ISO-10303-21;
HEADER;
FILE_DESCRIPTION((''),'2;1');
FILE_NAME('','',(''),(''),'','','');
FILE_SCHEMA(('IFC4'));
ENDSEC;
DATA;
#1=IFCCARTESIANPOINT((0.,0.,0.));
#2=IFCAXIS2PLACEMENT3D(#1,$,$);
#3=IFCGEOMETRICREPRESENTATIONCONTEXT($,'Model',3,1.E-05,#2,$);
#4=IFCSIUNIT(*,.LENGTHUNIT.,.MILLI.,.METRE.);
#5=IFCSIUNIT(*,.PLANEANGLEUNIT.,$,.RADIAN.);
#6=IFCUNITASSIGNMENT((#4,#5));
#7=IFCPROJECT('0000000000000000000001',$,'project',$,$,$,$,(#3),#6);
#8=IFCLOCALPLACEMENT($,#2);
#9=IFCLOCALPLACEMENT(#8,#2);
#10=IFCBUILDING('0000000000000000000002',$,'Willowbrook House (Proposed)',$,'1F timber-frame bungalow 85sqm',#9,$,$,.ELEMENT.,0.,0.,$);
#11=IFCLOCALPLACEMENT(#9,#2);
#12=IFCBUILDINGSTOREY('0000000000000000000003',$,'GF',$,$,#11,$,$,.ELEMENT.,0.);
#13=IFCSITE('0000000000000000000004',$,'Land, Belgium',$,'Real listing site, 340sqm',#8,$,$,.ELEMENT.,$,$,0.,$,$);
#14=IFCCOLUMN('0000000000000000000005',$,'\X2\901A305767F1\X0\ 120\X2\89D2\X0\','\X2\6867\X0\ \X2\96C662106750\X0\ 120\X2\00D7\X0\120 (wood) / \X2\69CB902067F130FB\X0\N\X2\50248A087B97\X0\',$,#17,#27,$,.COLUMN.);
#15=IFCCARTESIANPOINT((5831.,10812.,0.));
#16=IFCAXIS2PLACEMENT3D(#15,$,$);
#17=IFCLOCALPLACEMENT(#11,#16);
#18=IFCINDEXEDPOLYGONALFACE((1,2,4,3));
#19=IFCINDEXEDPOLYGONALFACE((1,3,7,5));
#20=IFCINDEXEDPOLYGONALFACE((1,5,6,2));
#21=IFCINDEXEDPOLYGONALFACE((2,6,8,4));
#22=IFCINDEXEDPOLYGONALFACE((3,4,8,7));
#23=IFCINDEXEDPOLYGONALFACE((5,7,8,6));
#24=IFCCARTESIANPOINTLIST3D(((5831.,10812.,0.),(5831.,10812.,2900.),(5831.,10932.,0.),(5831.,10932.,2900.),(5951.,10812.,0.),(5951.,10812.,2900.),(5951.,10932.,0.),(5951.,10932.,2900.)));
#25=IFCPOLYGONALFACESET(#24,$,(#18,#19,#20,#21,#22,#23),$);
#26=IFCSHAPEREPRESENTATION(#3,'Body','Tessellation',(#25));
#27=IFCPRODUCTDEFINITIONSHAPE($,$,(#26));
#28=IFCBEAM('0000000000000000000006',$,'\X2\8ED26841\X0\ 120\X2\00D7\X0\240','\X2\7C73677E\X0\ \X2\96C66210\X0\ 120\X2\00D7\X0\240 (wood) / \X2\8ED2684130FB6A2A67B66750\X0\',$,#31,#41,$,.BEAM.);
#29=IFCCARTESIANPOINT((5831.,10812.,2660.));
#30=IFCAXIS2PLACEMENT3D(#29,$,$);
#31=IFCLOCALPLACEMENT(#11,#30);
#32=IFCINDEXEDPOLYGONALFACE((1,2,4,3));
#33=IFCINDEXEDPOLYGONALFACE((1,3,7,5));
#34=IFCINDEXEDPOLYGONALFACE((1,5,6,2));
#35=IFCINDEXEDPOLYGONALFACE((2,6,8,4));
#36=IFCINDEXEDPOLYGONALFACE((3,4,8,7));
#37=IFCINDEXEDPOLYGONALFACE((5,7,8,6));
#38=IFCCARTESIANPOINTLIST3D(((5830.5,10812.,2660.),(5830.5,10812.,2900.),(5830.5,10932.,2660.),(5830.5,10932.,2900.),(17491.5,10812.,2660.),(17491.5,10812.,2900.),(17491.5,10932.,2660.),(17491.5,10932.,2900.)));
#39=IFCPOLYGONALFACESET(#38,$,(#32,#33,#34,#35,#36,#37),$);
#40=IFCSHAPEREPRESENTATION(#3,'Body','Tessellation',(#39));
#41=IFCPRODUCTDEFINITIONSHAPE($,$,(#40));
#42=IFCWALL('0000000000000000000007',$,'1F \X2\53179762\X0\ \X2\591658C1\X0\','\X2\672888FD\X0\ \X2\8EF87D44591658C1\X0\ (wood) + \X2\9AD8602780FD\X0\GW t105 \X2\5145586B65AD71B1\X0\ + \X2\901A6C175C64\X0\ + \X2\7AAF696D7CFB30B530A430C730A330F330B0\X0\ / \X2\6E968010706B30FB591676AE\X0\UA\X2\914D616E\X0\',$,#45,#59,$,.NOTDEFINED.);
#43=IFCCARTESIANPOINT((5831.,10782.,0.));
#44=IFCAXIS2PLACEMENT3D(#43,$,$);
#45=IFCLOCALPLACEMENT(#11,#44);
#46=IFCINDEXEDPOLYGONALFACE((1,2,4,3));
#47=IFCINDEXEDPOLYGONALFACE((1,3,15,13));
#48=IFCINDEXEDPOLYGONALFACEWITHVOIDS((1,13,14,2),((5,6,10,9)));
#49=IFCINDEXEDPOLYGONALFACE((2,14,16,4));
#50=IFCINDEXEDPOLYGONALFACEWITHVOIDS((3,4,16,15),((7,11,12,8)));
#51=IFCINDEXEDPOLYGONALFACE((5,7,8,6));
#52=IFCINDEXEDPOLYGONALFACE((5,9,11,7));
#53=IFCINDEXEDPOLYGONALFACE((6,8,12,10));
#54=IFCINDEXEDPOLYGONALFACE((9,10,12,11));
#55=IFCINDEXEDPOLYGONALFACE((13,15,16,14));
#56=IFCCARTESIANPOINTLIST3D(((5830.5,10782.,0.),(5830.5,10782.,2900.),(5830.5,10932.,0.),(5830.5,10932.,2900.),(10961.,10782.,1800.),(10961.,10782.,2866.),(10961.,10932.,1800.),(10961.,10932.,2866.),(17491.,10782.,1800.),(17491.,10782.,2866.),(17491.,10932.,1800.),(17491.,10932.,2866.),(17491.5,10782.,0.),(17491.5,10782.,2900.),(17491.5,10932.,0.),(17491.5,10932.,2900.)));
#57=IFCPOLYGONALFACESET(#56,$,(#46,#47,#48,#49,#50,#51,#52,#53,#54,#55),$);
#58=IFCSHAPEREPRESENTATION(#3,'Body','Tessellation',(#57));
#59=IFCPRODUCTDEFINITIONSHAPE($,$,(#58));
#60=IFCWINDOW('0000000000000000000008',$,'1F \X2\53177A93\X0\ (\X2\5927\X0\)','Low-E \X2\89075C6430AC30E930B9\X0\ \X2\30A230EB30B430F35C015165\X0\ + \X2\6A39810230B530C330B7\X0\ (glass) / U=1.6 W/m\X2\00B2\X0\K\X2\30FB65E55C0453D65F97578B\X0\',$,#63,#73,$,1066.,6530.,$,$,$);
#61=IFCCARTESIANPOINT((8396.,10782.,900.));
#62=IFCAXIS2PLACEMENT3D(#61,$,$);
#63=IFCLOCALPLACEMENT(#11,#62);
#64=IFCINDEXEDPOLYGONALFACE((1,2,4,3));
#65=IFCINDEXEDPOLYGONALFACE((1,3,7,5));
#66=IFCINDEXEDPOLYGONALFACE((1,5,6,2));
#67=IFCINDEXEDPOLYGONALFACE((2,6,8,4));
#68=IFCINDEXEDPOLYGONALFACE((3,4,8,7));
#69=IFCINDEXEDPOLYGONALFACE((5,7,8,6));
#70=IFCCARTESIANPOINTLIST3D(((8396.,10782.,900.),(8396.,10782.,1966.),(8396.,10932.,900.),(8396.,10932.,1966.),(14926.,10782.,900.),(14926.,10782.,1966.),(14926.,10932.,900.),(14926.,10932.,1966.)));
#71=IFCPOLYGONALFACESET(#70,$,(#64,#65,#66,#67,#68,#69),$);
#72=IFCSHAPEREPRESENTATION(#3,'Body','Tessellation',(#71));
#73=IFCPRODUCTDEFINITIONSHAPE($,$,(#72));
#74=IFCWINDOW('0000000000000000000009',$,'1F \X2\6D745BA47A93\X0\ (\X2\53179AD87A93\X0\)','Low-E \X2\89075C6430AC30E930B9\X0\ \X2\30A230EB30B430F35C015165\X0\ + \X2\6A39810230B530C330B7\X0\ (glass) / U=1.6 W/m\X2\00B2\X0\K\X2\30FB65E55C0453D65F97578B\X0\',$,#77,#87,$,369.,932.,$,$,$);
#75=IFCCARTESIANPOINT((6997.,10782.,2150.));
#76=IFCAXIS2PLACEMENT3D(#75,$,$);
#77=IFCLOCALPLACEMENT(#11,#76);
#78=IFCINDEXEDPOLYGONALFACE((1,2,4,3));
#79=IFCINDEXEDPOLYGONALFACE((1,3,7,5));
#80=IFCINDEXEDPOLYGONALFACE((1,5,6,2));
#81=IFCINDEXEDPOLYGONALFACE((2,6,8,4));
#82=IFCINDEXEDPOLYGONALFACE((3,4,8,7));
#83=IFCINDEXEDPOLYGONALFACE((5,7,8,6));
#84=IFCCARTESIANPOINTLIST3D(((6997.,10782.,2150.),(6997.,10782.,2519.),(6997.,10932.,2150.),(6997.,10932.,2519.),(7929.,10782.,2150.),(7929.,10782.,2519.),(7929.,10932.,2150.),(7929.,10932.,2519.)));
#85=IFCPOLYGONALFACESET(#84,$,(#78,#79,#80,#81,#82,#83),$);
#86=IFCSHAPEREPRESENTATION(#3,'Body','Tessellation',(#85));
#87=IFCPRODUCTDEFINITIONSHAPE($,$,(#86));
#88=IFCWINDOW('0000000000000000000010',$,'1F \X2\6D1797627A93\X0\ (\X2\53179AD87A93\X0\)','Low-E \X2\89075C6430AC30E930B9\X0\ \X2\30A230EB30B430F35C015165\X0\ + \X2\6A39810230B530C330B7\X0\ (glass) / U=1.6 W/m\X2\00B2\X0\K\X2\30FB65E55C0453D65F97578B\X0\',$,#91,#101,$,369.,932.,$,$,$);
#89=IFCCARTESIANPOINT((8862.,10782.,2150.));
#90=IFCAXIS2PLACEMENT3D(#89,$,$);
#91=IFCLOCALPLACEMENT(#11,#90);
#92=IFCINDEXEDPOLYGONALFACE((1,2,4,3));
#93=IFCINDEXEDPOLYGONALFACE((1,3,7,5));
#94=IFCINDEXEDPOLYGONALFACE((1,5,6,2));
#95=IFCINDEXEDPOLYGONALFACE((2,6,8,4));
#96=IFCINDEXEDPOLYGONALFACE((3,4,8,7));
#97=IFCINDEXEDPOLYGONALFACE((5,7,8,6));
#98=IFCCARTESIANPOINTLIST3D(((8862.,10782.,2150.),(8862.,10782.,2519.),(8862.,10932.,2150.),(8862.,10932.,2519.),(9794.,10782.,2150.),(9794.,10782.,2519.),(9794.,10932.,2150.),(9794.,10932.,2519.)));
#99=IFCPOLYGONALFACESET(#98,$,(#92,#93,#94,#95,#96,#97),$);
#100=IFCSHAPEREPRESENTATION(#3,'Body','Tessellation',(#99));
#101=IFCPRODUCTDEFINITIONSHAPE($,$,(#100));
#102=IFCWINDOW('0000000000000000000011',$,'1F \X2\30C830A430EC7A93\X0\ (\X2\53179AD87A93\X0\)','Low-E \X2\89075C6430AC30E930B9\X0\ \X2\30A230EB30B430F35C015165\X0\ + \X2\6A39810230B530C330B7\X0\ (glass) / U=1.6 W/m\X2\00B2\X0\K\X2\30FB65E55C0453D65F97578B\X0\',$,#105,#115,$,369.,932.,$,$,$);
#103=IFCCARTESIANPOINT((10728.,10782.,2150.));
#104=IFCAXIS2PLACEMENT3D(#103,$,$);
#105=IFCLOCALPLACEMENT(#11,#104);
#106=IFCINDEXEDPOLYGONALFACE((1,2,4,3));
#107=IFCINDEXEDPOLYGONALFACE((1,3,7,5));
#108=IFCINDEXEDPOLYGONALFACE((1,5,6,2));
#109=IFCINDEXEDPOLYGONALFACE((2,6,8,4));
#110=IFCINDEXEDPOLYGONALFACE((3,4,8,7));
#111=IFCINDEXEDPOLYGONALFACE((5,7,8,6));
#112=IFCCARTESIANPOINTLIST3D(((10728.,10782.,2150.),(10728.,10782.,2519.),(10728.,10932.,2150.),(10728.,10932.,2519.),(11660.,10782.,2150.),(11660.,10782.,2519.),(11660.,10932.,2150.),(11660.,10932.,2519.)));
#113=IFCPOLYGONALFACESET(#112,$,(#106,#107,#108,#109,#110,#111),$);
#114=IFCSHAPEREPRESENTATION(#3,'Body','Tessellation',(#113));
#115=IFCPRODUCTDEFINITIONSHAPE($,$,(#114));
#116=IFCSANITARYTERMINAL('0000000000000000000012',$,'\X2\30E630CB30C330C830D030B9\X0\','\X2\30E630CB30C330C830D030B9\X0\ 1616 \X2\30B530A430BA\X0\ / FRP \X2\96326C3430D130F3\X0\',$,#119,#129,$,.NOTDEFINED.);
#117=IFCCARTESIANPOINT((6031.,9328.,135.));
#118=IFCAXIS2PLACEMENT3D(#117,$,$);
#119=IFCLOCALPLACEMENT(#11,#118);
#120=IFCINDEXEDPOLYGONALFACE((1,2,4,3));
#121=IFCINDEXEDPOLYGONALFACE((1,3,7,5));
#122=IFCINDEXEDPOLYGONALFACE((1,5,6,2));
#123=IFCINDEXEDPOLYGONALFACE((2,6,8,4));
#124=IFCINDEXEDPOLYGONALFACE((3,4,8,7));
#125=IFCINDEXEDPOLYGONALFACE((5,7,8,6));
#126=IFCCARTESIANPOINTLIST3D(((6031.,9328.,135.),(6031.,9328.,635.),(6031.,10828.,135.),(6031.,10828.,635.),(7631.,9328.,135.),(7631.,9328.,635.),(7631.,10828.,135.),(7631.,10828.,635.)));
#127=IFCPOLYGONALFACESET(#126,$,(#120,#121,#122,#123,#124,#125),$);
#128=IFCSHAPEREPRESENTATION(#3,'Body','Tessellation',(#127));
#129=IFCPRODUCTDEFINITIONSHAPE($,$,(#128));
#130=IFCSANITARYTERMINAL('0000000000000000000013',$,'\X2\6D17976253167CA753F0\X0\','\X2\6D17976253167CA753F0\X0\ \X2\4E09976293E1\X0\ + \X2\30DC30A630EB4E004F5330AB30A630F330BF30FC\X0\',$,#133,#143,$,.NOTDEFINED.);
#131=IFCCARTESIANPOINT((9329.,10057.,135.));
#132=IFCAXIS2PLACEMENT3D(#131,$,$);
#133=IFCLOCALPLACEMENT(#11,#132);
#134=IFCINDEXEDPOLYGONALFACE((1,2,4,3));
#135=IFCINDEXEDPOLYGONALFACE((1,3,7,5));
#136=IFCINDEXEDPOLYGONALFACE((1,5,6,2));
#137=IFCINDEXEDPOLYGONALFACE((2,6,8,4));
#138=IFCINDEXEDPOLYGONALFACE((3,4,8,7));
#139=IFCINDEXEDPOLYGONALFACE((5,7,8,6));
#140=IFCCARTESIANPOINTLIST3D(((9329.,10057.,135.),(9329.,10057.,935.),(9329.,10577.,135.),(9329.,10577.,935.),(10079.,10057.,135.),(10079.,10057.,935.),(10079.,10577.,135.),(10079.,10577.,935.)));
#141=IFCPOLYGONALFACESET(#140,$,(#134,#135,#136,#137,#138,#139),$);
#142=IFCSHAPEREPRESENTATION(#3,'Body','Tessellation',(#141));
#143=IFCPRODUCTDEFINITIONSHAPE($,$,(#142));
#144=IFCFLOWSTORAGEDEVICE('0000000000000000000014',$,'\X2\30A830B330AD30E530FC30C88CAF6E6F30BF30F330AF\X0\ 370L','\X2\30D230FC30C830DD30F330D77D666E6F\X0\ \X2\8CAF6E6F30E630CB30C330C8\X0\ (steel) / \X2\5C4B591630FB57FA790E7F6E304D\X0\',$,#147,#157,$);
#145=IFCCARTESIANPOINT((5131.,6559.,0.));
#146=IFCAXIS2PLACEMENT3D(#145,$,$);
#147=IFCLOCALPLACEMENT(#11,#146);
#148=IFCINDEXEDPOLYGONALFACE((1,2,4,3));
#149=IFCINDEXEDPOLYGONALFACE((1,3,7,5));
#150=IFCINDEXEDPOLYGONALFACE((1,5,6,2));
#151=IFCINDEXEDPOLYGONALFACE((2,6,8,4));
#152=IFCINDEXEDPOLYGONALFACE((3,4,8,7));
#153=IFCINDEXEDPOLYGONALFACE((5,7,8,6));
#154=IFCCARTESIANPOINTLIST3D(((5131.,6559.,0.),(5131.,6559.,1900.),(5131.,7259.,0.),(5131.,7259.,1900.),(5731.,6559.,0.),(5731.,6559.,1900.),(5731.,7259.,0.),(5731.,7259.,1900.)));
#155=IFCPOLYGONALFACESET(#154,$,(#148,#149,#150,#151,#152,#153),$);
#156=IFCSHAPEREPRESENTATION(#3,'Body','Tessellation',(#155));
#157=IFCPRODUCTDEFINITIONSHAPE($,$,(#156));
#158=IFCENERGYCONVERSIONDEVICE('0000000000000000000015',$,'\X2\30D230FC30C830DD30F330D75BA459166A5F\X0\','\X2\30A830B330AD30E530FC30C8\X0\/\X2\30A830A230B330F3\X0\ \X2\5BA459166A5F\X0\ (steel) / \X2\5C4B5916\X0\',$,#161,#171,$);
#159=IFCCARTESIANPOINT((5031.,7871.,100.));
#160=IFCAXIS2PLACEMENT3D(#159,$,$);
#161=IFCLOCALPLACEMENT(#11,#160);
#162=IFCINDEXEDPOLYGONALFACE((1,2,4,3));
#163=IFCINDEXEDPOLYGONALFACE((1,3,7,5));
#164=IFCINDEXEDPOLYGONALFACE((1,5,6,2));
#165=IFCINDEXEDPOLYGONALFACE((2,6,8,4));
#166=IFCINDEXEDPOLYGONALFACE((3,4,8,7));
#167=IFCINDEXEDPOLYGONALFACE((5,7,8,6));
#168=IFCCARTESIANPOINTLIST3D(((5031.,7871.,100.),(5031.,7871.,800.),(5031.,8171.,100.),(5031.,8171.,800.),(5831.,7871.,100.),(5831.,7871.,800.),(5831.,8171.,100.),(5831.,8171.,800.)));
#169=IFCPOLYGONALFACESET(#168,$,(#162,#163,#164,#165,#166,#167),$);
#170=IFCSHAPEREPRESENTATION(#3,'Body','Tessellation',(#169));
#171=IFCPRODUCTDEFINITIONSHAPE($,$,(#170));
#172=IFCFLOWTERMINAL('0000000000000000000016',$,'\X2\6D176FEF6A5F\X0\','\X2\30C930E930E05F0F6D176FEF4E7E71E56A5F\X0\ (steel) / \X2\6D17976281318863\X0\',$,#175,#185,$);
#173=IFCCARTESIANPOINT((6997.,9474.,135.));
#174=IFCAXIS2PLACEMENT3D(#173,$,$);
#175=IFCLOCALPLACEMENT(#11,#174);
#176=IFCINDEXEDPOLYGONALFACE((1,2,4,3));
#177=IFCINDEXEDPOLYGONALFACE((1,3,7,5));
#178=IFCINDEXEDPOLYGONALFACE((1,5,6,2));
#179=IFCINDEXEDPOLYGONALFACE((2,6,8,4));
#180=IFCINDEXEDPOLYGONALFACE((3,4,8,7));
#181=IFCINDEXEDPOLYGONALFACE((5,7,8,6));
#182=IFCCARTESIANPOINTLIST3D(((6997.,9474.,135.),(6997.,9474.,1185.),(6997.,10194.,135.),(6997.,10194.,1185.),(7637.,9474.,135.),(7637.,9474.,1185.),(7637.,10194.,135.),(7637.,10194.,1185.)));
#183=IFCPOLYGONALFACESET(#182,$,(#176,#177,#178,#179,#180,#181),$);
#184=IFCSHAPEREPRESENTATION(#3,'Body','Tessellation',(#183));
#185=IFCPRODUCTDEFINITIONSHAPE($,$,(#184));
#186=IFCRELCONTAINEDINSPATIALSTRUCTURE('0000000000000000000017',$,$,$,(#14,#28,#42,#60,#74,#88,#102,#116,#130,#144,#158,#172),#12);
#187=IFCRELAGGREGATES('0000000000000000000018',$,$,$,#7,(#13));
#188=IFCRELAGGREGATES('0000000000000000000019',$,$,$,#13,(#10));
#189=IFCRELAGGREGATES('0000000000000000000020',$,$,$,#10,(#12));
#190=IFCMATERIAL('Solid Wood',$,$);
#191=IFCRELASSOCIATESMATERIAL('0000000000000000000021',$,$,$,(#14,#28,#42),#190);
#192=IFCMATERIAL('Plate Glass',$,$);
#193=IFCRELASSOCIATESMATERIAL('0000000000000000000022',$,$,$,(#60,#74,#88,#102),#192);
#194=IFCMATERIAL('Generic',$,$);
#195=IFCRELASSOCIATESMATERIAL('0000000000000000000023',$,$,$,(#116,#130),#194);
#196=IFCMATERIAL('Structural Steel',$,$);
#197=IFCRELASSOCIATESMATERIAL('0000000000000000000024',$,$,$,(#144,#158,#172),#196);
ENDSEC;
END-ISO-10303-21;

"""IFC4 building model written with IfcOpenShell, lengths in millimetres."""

from ifc_helpers import new_model, si_unit, frame, frame_2d, origin, place, context, project, spatial, rectangle, extrude, material, element, fill, save


model = new_model("IFC4")

# Units and contexts
model_context = context("Model", 3, precision=1e-05, world=origin())
ifc_project = project(units=[si_unit("LENGTHUNIT", "METRE", prefix="MILLI"), si_unit("PLANEANGLEUNIT", "RADIAN")], contexts=[model_context])

# Site, building, storey
site_placement = place(None, origin())
site = spatial("IfcSite", under=ifc_project, at=site_placement, Name="Land, Belgium", ObjectType="Real listing site, 340sqm", CompositionType="ELEMENT", RefElevation=0.0)
building_placement = place(site_placement, origin())
building = spatial("IfcBuilding", under=site, at=building_placement, Name="Willowbrook House (Proposed)", ObjectType="1F timber-frame bungalow 85sqm", CompositionType="ELEMENT", ElevationOfRefHeight=0.0, ElevationOfTerrain=0.0)
storey_placement = place(building_placement, origin())
storey = spatial("IfcBuildingStorey", under=building, at=storey_placement, Name="GF", CompositionType="ELEMENT", Elevation=0.0)

# Column
ifc_material_1 = material(Name="Solid Wood")
column_1_placement = place(storey_placement, frame((5831.0, 10812.0, 0.0)))
element("IfcColumn", 1, at=column_1_placement, inside=storey, material=ifc_material_1, Name="通し柱 120角", Description="桧 集成材 120×120 (wood) / 構造柱・N値計算", PredefinedType="COLUMN", context=model_context, shape_type="SweptSolid", body=[
    extrude(rectangle(XDim=120.0, YDim=120.0, at=frame_2d((60.0, 60.0))), frame((5831.0, 10812.0, 0.0)), (0.0, 0.0, 1.0), 2900.0),
])

# Beam
beam_1_placement = place(storey_placement, frame((5831.0, 10812.0, 2660.0)))
element("IfcBeam", 2, at=beam_1_placement, inside=storey, material=ifc_material_1, Name="軒桁 120×240", Description="米松 集成 120×240 (wood) / 軒桁・横架材", PredefinedType="BEAM", context=model_context, shape_type="SweptSolid", body=[
    extrude(rectangle(XDim=11661.0, YDim=120.0, at=frame_2d((5830.0, 60.0))), frame((5831.0, 10812.0, 2660.0)), (0.0, 0.0, 1.0), 240.0),
])

# Wall, openings, windows
wall_1_placement = place(storey_placement, frame((5831.0, 10782.0, 0.0)))
wall_1 = element("IfcWall", 3, at=wall_1_placement, inside=storey, material=ifc_material_1, Name="1F 北面 外壁", Description="木製 軸組外壁 (wood) + 高性能GW t105 充填断熱 + 通気層 + 窯業系サイディング / 準耐火・外皮UA配慮", PredefinedType="NOTDEFINED", context=model_context, shape_type="SweptSolid", body=[
    extrude(rectangle(XDim=11661.0, YDim=150.0, at=frame_2d((5830.0, 75.0))), frame((5831.0, 10782.0, 0.0)), (0.0, 0.0, 1.0), 2900.0),
])
opening_1_placement = place(storey_placement, frame((8396.0, 10782.0, 900.0)))
opening_1 = element("IfcOpeningElement", 4, at=opening_1_placement, cuts=wall_1, PredefinedType="NOTDEFINED", context=model_context, shape_type="SweptSolid", body=[
    extrude(rectangle(XDim=6530.0, YDim=150.0, at=frame_2d((3265.0, 75.0))), frame((8396.0, 10782.0, 900.0)), (0.0, 0.0, 1.0), 1066.0),
])
opening_2_placement = place(storey_placement, frame((6997.0, 10782.0, 2150.0)))
opening_2 = element("IfcOpeningElement", 5, at=opening_2_placement, cuts=wall_1, PredefinedType="NOTDEFINED", context=model_context, shape_type="SweptSolid", body=[
    extrude(rectangle(XDim=932.0, YDim=150.0, at=frame_2d((466.0, 75.0))), frame((6997.0, 10782.0, 2150.0)), (0.0, 0.0, 1.0), 369.0),
])
opening_3_placement = place(storey_placement, frame((8862.0, 10782.0, 2150.0)))
opening_3 = element("IfcOpeningElement", 6, at=opening_3_placement, cuts=wall_1, PredefinedType="NOTDEFINED", context=model_context, shape_type="SweptSolid", body=[
    extrude(rectangle(XDim=932.0, YDim=150.0, at=frame_2d((466.0, 75.0))), frame((8862.0, 10782.0, 2150.0)), (0.0, 0.0, 1.0), 369.0),
])
opening_4_placement = place(storey_placement, frame((10728.0, 10782.0, 2150.0)))
opening_4 = element("IfcOpeningElement", 7, at=opening_4_placement, cuts=wall_1, PredefinedType="NOTDEFINED", context=model_context, shape_type="SweptSolid", body=[
    extrude(rectangle(XDim=932.0, YDim=150.0, at=frame_2d((466.0, 75.0))), frame((10728.0, 10782.0, 2150.0)), (0.0, 0.0, 1.0), 369.0),
])
ifc_material_2 = material(Name="Plate Glass")
window_1_placement = place(storey_placement, frame((8396.0, 10782.0, 900.0)))
window_1 = element("IfcWindow", 8, at=window_1_placement, inside=storey, material=ifc_material_2, Name="1F 北窓 (大)", Description="Low-E 複層ガラス アルゴン封入 + 樹脂サッシ (glass) / U=1.6 W/m²K・日射取得型", OverallHeight=1066.0, OverallWidth=6530.0, context=model_context, shape_type="SweptSolid", body=[
    extrude(rectangle(XDim=6530.0, YDim=150.0, at=frame_2d((3265.0, 75.0))), frame((8396.0, 10782.0, 900.0)), (0.0, 0.0, 1.0), 1066.0),
])
fill(opening_1, window_1)
window_2_placement = place(storey_placement, frame((6997.0, 10782.0, 2150.0)))
window_2 = element("IfcWindow", 9, at=window_2_placement, inside=storey, material=ifc_material_2, Name="1F 浴室窓 (北高窓)", Description="Low-E 複層ガラス アルゴン封入 + 樹脂サッシ (glass) / U=1.6 W/m²K・日射取得型", OverallHeight=369.0, OverallWidth=932.0, context=model_context, shape_type="SweptSolid", body=[
    extrude(rectangle(XDim=932.0, YDim=150.0, at=frame_2d((466.0, 75.0))), frame((6997.0, 10782.0, 2150.0)), (0.0, 0.0, 1.0), 369.0),
])
fill(opening_2, window_2)
window_3_placement = place(storey_placement, frame((8862.0, 10782.0, 2150.0)))
window_3 = element("IfcWindow", 10, at=window_3_placement, inside=storey, material=ifc_material_2, Name="1F 洗面窓 (北高窓)", Description="Low-E 複層ガラス アルゴン封入 + 樹脂サッシ (glass) / U=1.6 W/m²K・日射取得型", OverallHeight=369.0, OverallWidth=932.0, context=model_context, shape_type="SweptSolid", body=[
    extrude(rectangle(XDim=932.0, YDim=150.0, at=frame_2d((466.0, 75.0))), frame((8862.0, 10782.0, 2150.0)), (0.0, 0.0, 1.0), 369.0),
])
fill(opening_3, window_3)
window_4_placement = place(storey_placement, frame((10728.0, 10782.0, 2150.0)))
window_4 = element("IfcWindow", 11, at=window_4_placement, inside=storey, material=ifc_material_2, Name="1F トイレ窓 (北高窓)", Description="Low-E 複層ガラス アルゴン封入 + 樹脂サッシ (glass) / U=1.6 W/m²K・日射取得型", OverallHeight=369.0, OverallWidth=932.0, context=model_context, shape_type="SweptSolid", body=[
    extrude(rectangle(XDim=932.0, YDim=150.0, at=frame_2d((466.0, 75.0))), frame((10728.0, 10782.0, 2150.0)), (0.0, 0.0, 1.0), 369.0),
])
fill(opening_4, window_4)

# Sanitary terminals
ifc_material_3 = material(Name="Generic")
sanitary_terminal_1_placement = place(storey_placement, frame((6031.0, 9328.0, 135.0)))
element("IfcSanitaryTerminal", 12, at=sanitary_terminal_1_placement, inside=storey, material=ifc_material_3, Name="ユニットバス", Description="ユニットバス 1616 サイズ / FRP 防水パン", PredefinedType="NOTDEFINED", context=model_context, shape_type="SweptSolid", body=[
    extrude(rectangle(XDim=1600.0, YDim=1500.0, at=frame_2d((800.0, 750.0))), frame((6031.0, 9328.0, 135.0)), (0.0, 0.0, 1.0), 500.0),
])
sanitary_terminal_2_placement = place(storey_placement, frame((9329.0, 10057.0, 135.0)))
element("IfcSanitaryTerminal", 13, at=sanitary_terminal_2_placement, inside=storey, material=ifc_material_3, Name="洗面化粧台", Description="洗面化粧台 三面鏡 + ボウル一体カウンター", PredefinedType="NOTDEFINED", context=model_context, shape_type="SweptSolid", body=[
    extrude(rectangle(XDim=750.0, YDim=520.0, at=frame_2d((375.0, 260.0))), frame((9329.0, 10057.0, 135.0)), (0.0, 0.0, 1.0), 800.0),
])

# Flow storage device
ifc_material_4 = material(Name="Structural Steel")
flow_storage_device_placement = place(storey_placement, frame((5131.0, 6559.0, 0.0)))
element("IfcFlowStorageDevice", 14, at=flow_storage_device_placement, inside=storey, material=ifc_material_4, Name="エコキュート貯湯タンク 370L", Description="ヒートポンプ給湯 貯湯ユニット (steel) / 屋外・基礎置き", context=model_context, shape_type="SweptSolid", body=[
    extrude(rectangle(XDim=600.0, YDim=700.0, at=frame_2d((300.0, 350.0))), frame((5131.0, 6559.0, 0.0)), (0.0, 0.0, 1.0), 1900.0),
])

# Energy conversion device
energy_conversion_device_placement = place(storey_placement, frame((5031.0, 7871.0, 100.0)))
element("IfcEnergyConversionDevice", 15, at=energy_conversion_device_placement, inside=storey, material=ifc_material_4, Name="ヒートポンプ室外機", Description="エコキュート/エアコン 室外機 (steel) / 屋外", context=model_context, shape_type="SweptSolid", body=[
    extrude(rectangle(XDim=800.0, YDim=300.0, at=frame_2d((400.0, 150.0))), frame((5031.0, 7871.0, 100.0)), (0.0, 0.0, 1.0), 700.0),
])

# Flow terminal
flow_terminal_placement = place(storey_placement, frame((6997.0, 9474.0, 135.0)))
element("IfcFlowTerminal", 16, at=flow_terminal_placement, inside=storey, material=ifc_material_4, Name="洗濯機", Description="ドラム式洗濯乾燥機 (steel) / 洗面脱衣", context=model_context, shape_type="SweptSolid", body=[
    extrude(rectangle(XDim=640.0, YDim=720.0, at=frame_2d((320.0, 360.0))), frame((6997.0, 9474.0, 135.0)), (0.0, 0.0, 1.0), 1050.0),
])

save(model, "model.ifc")
